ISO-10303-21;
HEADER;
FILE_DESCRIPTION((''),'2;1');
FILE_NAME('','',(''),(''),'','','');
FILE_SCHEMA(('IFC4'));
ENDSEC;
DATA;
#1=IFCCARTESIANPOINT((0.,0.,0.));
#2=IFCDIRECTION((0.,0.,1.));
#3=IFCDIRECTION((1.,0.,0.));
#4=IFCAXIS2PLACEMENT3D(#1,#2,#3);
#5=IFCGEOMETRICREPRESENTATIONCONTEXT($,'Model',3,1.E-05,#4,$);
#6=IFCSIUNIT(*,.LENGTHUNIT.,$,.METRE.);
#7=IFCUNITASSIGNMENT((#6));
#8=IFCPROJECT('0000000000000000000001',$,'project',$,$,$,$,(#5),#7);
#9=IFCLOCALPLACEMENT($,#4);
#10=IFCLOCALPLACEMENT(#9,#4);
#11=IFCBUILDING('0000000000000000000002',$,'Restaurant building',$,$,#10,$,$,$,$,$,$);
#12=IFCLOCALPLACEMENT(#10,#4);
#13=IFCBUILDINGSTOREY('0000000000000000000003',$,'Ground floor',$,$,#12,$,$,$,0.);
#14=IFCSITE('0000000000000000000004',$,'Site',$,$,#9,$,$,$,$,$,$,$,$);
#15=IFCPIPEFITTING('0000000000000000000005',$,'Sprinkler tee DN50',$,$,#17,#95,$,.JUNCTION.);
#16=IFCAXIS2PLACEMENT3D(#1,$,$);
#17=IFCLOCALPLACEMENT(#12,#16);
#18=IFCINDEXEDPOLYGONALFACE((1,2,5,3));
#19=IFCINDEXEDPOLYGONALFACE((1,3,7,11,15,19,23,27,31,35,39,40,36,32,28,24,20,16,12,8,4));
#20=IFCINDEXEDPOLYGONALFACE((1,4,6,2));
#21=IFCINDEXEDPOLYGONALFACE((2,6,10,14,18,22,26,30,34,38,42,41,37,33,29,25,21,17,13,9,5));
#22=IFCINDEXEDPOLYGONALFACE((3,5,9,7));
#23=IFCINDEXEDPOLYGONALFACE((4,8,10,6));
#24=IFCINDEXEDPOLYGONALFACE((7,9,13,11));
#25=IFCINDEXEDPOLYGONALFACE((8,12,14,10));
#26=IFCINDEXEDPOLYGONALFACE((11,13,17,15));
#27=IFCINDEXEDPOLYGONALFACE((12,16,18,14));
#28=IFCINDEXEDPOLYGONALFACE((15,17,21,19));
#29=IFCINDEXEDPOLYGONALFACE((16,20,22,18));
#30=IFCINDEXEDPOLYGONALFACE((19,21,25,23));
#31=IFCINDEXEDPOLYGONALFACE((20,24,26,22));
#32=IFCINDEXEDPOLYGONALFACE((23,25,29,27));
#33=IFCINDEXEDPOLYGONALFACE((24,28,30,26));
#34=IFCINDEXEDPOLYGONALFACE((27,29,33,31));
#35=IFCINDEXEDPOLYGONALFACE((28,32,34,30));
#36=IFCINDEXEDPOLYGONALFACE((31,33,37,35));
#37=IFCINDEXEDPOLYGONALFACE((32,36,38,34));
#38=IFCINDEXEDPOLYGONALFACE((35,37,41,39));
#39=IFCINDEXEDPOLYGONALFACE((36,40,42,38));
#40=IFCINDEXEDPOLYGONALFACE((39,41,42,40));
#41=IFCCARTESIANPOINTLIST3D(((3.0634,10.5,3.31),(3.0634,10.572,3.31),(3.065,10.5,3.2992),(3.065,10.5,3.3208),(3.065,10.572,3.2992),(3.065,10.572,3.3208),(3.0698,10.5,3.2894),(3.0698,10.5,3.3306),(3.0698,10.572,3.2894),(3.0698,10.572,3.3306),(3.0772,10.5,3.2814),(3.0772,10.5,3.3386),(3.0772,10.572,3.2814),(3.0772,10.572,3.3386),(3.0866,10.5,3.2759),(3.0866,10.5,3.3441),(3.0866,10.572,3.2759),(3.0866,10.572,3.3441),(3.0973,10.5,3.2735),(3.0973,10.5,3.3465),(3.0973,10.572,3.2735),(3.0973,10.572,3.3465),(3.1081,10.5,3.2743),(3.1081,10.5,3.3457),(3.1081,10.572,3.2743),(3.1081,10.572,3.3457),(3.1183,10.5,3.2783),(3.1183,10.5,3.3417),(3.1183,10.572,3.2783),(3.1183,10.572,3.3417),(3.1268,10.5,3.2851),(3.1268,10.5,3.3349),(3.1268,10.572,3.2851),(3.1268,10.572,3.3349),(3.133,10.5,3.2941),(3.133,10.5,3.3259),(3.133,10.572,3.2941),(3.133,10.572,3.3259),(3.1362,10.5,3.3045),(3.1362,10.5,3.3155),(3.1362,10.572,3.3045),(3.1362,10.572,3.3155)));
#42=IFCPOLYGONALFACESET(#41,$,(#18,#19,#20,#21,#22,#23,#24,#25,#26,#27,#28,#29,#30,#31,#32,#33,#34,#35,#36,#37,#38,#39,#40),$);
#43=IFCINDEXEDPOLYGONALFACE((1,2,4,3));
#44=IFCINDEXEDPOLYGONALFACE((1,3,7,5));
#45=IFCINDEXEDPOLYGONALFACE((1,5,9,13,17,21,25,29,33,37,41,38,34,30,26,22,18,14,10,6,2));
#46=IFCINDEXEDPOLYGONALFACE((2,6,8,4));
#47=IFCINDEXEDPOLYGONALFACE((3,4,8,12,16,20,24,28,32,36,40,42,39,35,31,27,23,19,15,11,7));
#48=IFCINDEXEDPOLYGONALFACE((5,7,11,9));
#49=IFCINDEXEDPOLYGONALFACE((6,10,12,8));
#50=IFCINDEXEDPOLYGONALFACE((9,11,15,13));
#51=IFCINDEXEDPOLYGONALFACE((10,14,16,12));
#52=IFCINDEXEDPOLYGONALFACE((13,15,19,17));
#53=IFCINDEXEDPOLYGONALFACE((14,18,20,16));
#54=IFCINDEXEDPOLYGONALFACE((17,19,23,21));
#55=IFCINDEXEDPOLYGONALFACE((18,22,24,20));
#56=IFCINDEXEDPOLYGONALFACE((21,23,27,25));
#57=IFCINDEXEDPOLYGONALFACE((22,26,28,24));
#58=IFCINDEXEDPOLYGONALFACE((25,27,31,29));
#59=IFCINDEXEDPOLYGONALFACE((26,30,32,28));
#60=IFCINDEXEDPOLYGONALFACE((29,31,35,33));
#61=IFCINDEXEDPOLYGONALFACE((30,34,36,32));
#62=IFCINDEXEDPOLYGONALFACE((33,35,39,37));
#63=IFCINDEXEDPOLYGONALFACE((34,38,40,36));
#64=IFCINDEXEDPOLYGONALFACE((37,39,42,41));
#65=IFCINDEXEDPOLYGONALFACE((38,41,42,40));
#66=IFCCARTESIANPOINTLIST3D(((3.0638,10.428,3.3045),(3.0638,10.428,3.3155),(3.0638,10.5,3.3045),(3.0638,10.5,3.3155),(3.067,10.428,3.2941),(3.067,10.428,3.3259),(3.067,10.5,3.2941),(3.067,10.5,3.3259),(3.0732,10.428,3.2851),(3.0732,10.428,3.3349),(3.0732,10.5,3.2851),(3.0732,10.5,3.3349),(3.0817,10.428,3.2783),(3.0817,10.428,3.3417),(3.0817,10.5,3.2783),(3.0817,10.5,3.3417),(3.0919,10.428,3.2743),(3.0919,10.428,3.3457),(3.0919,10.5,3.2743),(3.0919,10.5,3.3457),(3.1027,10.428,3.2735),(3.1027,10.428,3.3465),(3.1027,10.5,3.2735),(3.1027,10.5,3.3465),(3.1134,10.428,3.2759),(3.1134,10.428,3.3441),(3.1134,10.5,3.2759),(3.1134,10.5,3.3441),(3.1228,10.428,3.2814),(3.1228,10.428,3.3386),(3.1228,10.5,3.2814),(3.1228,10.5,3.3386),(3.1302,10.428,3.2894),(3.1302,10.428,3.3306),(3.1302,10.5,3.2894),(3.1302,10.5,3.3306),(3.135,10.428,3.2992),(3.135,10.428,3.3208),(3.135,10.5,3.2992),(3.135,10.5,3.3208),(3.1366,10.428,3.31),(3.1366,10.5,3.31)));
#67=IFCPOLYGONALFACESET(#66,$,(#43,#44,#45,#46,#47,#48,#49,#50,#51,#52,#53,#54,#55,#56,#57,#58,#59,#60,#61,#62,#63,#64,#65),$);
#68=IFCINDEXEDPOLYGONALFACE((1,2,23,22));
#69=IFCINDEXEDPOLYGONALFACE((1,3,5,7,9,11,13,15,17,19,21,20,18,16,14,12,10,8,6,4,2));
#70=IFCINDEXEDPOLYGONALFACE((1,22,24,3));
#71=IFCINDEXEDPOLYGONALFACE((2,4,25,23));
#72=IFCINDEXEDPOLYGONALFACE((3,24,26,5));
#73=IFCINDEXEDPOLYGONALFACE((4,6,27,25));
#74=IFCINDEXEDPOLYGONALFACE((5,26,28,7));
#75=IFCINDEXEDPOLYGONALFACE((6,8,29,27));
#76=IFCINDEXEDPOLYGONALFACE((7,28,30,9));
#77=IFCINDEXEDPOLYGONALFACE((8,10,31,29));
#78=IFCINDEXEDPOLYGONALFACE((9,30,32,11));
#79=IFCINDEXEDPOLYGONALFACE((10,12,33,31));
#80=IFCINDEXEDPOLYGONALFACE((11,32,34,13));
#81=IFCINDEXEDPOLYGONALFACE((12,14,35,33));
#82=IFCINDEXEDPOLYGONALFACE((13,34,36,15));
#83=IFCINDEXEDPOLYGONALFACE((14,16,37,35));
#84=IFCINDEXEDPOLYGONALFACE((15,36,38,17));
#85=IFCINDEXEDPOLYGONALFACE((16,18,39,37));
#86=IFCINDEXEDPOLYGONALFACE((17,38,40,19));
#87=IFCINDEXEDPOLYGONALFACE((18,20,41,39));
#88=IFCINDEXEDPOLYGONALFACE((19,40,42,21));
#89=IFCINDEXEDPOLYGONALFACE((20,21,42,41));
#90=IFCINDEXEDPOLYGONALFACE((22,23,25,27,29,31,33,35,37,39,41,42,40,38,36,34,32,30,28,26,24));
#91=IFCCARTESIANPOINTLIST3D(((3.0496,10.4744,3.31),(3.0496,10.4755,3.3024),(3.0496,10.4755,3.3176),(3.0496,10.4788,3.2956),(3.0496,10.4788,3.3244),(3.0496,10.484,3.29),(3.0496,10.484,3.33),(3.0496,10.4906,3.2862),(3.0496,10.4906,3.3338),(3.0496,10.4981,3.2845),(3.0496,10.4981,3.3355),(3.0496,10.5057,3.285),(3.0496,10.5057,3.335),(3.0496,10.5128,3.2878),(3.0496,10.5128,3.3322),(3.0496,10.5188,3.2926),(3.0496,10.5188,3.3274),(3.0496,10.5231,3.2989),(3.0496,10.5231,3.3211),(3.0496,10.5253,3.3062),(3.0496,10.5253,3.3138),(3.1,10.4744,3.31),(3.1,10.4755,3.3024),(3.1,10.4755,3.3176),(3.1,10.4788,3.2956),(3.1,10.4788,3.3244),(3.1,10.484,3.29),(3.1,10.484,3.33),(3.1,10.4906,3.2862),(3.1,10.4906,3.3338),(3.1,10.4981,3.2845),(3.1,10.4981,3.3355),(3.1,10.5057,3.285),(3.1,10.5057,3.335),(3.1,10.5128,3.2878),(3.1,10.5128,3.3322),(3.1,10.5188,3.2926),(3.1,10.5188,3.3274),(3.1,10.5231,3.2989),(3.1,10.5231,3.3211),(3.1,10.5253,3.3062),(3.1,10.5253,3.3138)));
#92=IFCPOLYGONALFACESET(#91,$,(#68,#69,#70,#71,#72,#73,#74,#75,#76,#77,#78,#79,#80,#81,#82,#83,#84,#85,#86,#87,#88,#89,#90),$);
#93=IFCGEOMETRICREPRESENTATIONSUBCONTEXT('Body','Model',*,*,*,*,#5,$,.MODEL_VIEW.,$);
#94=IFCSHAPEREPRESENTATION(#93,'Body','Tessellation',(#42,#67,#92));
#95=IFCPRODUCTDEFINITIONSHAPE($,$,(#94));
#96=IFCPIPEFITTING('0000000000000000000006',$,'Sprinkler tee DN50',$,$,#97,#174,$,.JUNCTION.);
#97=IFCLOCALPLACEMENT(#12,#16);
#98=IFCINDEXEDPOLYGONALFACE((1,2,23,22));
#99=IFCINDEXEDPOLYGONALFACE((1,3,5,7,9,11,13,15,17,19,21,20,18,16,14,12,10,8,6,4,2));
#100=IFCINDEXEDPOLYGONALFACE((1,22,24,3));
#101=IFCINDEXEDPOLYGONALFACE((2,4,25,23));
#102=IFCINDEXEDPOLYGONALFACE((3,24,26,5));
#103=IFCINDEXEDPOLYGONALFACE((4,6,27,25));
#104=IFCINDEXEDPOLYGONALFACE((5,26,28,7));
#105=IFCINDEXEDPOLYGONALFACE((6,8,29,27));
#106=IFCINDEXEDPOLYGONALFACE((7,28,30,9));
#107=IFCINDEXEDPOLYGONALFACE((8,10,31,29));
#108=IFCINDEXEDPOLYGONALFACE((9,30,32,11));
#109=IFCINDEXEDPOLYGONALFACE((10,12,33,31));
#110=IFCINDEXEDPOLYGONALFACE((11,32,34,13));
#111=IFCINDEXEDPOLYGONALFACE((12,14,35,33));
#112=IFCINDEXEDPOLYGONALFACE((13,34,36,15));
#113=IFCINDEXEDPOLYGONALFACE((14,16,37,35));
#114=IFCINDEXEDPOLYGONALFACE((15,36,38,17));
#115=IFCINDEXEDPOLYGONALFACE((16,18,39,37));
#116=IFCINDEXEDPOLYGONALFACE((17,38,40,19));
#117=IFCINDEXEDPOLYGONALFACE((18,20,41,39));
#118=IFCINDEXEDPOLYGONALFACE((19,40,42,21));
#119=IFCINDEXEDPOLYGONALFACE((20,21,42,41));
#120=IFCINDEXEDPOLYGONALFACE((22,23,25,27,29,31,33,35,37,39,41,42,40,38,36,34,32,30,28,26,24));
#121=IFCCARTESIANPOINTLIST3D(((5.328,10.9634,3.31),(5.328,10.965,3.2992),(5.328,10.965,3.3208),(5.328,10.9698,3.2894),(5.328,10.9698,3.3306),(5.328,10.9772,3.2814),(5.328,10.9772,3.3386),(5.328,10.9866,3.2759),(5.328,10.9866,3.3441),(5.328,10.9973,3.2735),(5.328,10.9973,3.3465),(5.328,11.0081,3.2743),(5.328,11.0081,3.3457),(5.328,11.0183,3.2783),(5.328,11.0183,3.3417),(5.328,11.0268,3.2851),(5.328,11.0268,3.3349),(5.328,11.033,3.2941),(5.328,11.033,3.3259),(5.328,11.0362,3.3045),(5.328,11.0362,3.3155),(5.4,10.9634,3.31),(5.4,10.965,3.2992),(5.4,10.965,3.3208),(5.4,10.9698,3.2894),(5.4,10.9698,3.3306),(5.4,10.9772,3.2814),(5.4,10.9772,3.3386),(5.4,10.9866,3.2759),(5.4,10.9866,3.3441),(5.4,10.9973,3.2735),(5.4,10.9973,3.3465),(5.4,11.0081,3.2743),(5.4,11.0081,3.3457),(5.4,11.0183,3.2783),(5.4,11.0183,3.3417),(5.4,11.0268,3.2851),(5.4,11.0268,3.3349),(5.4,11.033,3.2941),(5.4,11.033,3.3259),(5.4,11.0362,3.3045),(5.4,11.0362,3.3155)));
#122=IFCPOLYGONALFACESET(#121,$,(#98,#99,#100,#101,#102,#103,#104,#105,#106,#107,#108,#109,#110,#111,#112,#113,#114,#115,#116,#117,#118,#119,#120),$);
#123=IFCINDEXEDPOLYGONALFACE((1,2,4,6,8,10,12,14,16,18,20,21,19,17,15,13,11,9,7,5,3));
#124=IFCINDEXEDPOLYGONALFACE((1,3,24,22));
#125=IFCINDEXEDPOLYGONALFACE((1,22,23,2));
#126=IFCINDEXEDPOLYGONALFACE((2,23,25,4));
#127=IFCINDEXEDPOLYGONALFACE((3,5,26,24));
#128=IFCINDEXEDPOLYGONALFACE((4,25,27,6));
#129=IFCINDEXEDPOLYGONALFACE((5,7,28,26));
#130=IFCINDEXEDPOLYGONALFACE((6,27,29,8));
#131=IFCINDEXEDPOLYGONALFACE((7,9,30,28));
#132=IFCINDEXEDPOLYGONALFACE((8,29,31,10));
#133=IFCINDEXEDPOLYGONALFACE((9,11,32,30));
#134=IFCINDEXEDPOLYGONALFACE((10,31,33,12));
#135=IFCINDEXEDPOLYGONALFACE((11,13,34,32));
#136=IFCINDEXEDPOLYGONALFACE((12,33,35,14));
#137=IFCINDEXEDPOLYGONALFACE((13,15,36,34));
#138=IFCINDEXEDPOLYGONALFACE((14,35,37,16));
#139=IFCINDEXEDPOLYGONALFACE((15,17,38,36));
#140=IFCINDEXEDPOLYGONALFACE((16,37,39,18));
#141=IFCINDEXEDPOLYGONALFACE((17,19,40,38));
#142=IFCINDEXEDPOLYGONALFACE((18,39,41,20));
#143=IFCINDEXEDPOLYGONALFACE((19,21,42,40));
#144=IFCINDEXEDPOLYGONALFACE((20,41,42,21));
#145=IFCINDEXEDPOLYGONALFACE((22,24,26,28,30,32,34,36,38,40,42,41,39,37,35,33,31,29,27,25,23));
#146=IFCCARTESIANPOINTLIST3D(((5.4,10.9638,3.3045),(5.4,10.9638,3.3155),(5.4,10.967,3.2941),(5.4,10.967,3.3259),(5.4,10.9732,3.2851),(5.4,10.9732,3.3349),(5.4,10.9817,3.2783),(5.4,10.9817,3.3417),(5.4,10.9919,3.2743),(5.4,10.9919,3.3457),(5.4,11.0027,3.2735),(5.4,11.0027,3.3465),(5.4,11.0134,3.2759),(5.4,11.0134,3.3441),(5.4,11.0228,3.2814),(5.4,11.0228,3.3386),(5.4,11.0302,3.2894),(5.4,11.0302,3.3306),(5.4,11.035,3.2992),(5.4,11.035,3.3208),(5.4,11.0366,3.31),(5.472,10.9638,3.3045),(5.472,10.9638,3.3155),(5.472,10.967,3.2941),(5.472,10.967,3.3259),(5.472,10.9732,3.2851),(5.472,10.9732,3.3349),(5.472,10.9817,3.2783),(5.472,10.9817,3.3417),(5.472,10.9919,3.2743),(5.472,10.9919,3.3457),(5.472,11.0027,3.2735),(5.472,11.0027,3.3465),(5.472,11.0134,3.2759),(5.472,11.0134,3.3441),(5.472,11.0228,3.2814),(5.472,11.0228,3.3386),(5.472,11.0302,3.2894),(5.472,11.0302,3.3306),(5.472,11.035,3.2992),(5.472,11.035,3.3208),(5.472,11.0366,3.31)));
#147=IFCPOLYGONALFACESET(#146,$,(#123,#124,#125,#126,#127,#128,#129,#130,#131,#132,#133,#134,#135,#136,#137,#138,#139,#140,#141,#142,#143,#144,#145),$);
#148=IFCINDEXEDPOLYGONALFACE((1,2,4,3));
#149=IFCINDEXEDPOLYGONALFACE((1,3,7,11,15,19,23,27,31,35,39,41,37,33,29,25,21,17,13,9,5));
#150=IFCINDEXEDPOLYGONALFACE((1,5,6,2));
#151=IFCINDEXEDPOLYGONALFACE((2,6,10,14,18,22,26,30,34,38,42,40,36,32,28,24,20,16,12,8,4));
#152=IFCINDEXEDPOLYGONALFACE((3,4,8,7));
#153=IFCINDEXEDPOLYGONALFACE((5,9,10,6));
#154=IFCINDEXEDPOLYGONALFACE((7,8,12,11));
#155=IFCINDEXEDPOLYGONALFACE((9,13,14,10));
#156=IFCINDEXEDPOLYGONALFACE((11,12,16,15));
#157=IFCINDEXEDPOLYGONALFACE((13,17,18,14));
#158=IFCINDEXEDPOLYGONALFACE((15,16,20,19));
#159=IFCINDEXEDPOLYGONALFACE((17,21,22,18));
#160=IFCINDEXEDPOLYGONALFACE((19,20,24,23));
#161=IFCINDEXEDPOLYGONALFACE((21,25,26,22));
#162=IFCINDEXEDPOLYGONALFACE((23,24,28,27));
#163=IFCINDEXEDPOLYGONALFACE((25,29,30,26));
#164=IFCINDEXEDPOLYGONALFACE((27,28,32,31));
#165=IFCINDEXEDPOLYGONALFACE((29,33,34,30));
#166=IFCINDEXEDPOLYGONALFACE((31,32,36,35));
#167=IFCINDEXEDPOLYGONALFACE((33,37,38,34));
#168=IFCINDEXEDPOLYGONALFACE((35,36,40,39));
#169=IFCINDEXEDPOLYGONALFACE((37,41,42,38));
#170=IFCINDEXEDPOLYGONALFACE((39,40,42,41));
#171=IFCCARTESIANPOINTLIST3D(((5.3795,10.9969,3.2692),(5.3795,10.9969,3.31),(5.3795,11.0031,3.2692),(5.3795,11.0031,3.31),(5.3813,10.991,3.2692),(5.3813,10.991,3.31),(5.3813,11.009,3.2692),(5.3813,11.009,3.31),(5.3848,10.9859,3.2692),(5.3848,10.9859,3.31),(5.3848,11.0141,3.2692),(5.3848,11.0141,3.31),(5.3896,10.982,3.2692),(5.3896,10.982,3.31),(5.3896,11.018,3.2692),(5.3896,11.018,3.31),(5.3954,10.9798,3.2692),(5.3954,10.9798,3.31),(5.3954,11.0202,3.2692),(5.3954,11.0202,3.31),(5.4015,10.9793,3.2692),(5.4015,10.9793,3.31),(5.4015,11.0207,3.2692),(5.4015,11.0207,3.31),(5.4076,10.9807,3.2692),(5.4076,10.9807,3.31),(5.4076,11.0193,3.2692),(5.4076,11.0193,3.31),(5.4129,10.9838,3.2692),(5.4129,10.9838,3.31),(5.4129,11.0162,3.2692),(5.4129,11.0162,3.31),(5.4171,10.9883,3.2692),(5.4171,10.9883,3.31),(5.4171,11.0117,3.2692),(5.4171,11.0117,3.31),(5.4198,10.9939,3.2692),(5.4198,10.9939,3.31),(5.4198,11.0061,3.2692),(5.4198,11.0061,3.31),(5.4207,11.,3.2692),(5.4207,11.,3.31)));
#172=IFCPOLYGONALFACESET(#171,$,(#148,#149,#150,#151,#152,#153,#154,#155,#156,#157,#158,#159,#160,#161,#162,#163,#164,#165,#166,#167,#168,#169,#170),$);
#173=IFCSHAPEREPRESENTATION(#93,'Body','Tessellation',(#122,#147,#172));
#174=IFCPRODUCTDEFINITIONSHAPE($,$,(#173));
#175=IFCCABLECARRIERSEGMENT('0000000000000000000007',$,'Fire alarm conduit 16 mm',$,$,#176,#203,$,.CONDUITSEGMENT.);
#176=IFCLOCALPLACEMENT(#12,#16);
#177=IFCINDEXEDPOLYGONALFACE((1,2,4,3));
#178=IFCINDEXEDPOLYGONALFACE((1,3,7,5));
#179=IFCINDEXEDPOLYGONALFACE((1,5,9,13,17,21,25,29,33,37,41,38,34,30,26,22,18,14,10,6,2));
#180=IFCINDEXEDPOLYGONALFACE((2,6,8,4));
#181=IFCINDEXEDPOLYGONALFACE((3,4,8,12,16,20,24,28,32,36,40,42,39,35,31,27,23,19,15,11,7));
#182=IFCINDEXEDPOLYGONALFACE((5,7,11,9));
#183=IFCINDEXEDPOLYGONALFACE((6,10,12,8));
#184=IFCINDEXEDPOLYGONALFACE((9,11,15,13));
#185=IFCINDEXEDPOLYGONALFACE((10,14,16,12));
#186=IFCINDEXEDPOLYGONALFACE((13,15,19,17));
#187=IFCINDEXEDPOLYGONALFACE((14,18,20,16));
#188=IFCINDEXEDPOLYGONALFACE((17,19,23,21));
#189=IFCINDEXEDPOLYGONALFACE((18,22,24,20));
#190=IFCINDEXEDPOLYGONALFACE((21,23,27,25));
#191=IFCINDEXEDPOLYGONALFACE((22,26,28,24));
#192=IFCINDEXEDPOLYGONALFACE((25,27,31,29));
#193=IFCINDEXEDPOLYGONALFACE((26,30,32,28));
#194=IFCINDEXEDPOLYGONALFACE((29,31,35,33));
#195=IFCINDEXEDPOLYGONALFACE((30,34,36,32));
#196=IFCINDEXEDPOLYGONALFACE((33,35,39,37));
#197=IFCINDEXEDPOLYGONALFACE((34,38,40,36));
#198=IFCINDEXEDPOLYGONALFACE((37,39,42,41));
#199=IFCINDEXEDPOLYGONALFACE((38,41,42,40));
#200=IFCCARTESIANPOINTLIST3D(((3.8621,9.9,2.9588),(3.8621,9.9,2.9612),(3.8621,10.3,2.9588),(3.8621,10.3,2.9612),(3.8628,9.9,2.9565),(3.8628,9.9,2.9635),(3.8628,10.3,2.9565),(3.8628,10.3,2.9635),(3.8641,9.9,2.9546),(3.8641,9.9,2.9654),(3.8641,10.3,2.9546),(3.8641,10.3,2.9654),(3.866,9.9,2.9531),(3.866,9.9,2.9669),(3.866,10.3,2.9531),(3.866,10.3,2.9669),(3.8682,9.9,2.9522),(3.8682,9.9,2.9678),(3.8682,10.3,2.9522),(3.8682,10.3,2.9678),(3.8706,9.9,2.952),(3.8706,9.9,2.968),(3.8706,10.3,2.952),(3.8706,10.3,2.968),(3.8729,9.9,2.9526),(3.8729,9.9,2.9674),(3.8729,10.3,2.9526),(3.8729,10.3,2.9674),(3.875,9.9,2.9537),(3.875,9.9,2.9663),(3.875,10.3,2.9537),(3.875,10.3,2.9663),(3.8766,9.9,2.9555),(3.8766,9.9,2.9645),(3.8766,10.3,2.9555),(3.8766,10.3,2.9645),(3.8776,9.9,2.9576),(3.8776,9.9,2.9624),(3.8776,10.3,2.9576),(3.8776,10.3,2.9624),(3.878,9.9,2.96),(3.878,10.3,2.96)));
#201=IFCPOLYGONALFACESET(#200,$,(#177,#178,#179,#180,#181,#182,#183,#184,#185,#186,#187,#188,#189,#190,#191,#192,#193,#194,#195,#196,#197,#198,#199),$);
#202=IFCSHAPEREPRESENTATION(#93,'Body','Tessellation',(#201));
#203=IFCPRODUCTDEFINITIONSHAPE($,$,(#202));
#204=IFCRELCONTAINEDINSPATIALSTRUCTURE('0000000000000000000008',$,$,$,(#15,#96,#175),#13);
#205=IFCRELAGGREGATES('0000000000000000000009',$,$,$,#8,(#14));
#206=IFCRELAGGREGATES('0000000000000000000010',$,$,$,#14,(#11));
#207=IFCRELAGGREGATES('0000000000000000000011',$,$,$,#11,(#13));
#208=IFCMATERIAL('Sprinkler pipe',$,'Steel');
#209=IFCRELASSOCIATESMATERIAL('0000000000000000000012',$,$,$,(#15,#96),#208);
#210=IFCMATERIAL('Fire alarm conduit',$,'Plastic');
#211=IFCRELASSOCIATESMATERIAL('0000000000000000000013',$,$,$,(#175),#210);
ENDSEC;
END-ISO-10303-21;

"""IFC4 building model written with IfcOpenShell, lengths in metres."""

from ifc_helpers import new_model, si_unit, frame, origin_with_axes, origin_2d, place, context, subcontext, project, spatial, circle, extrude, material, element, save


model = new_model("IFC4")

# Units and contexts
model_context = context("Model", 3, precision=1e-05, world=origin_with_axes())
body_context = subcontext(model_context, "Body", "Model", "MODEL_VIEW")
ifc_project = project(units=[si_unit("LENGTHUNIT", "METRE")], contexts=[model_context])

# Site, building, storey
site_placement = place(None, origin_with_axes())
site = spatial("IfcSite", under=ifc_project, at=site_placement, Name="Site")
building_placement = place(site_placement, origin_with_axes())
building = spatial("IfcBuilding", under=site, at=building_placement, Name="Restaurant building")
storey_placement = place(building_placement, origin_with_axes())
storey = spatial("IfcBuildingStorey", under=building, at=storey_placement, Name="Ground floor", Elevation=0.0)

# Shared definitions
ifc_material_1 = material(Name="Sprinkler pipe", Category="Steel")

# Pipe fittings
pipe_fitting_1_placement = place(storey_placement, frame((3.1, 10.5, 3.31)))
element("IfcPipeFitting", 1, at=pipe_fitting_1_placement, inside=storey, material=ifc_material_1, Name="Sprinkler tee DN50", PredefinedType="JUNCTION", context=body_context, shape_type="SweptSolid", body=[
    extrude(circle(Radius=0.0366, at=origin_2d()), frame((0.0, 0.0, 0.0), z_axis=(0.0, 1.0, 0.0), x_axis=(-1.0, 0.0, 0.0)), (0.0, 0.0, 1.0), 0.072),
    extrude(circle(Radius=0.0366, at=origin_2d()), frame((0.0, 0.0, 0.0), z_axis=(0.0, -1.0, 0.0), x_axis=(1.0, 0.0, 0.0)), (0.0, 0.0, 1.0), 0.072),
    extrude(circle(Radius=0.0256, at=origin_2d()), frame((0.0, 0.0, 0.0), z_axis=(-1.0, 0.0, 0.0), x_axis=(0.0, -1.0, 0.0)), (0.0, 0.0, 1.0), 0.0504),
])
pipe_fitting_2_placement = place(storey_placement, frame((5.4, 11.0, 3.31)))
element("IfcPipeFitting", 2, at=pipe_fitting_2_placement, inside=storey, material=ifc_material_1, Name="Sprinkler tee DN50", PredefinedType="JUNCTION", context=body_context, shape_type="SweptSolid", body=[
    extrude(circle(Radius=0.0366, at=origin_2d()), frame((0.0, 0.0, 0.0), z_axis=(-1.0, 0.0, 0.0), x_axis=(0.0, -1.0, 0.0)), (0.0, 0.0, 1.0), 0.072),
    extrude(circle(Radius=0.0366, at=origin_2d()), frame((0.0, 0.0, 0.0), z_axis=(1.0, 0.0, 0.0), x_axis=(0.0, 1.0, 0.0)), (0.0, 0.0, 1.0), 0.072),
    extrude(circle(Radius=0.0207, at=origin_2d()), frame((0.0, 0.0, 0.0), z_axis=(0.0, 0.0, -1.0), x_axis=(1.0, 0.0, 0.0)), (0.0, 0.0, 1.0), 0.0408),
])

# Cable carrier segment
ifc_material_2 = material(Name="Fire alarm conduit", Category="Plastic")
cable_carrier_segment_1_placement = place(storey_placement, frame((3.87, 10.3, 2.96)))
element("IfcCableCarrierSegment", 3, at=cable_carrier_segment_1_placement, inside=storey, material=ifc_material_2, Name="Fire alarm conduit 16 mm", PredefinedType="CONDUITSEGMENT", context=body_context, shape_type="SweptSolid", body=[
    extrude(circle(Radius=0.008, at=origin_2d()), frame((0.0, 0.0, 0.0), z_axis=(0.0, -1.0, 0.0), x_axis=(1.0, 0.0, 0.0)), (0.0, 0.0, 1.0), 0.4),
])

save(model, "model.ifc")
